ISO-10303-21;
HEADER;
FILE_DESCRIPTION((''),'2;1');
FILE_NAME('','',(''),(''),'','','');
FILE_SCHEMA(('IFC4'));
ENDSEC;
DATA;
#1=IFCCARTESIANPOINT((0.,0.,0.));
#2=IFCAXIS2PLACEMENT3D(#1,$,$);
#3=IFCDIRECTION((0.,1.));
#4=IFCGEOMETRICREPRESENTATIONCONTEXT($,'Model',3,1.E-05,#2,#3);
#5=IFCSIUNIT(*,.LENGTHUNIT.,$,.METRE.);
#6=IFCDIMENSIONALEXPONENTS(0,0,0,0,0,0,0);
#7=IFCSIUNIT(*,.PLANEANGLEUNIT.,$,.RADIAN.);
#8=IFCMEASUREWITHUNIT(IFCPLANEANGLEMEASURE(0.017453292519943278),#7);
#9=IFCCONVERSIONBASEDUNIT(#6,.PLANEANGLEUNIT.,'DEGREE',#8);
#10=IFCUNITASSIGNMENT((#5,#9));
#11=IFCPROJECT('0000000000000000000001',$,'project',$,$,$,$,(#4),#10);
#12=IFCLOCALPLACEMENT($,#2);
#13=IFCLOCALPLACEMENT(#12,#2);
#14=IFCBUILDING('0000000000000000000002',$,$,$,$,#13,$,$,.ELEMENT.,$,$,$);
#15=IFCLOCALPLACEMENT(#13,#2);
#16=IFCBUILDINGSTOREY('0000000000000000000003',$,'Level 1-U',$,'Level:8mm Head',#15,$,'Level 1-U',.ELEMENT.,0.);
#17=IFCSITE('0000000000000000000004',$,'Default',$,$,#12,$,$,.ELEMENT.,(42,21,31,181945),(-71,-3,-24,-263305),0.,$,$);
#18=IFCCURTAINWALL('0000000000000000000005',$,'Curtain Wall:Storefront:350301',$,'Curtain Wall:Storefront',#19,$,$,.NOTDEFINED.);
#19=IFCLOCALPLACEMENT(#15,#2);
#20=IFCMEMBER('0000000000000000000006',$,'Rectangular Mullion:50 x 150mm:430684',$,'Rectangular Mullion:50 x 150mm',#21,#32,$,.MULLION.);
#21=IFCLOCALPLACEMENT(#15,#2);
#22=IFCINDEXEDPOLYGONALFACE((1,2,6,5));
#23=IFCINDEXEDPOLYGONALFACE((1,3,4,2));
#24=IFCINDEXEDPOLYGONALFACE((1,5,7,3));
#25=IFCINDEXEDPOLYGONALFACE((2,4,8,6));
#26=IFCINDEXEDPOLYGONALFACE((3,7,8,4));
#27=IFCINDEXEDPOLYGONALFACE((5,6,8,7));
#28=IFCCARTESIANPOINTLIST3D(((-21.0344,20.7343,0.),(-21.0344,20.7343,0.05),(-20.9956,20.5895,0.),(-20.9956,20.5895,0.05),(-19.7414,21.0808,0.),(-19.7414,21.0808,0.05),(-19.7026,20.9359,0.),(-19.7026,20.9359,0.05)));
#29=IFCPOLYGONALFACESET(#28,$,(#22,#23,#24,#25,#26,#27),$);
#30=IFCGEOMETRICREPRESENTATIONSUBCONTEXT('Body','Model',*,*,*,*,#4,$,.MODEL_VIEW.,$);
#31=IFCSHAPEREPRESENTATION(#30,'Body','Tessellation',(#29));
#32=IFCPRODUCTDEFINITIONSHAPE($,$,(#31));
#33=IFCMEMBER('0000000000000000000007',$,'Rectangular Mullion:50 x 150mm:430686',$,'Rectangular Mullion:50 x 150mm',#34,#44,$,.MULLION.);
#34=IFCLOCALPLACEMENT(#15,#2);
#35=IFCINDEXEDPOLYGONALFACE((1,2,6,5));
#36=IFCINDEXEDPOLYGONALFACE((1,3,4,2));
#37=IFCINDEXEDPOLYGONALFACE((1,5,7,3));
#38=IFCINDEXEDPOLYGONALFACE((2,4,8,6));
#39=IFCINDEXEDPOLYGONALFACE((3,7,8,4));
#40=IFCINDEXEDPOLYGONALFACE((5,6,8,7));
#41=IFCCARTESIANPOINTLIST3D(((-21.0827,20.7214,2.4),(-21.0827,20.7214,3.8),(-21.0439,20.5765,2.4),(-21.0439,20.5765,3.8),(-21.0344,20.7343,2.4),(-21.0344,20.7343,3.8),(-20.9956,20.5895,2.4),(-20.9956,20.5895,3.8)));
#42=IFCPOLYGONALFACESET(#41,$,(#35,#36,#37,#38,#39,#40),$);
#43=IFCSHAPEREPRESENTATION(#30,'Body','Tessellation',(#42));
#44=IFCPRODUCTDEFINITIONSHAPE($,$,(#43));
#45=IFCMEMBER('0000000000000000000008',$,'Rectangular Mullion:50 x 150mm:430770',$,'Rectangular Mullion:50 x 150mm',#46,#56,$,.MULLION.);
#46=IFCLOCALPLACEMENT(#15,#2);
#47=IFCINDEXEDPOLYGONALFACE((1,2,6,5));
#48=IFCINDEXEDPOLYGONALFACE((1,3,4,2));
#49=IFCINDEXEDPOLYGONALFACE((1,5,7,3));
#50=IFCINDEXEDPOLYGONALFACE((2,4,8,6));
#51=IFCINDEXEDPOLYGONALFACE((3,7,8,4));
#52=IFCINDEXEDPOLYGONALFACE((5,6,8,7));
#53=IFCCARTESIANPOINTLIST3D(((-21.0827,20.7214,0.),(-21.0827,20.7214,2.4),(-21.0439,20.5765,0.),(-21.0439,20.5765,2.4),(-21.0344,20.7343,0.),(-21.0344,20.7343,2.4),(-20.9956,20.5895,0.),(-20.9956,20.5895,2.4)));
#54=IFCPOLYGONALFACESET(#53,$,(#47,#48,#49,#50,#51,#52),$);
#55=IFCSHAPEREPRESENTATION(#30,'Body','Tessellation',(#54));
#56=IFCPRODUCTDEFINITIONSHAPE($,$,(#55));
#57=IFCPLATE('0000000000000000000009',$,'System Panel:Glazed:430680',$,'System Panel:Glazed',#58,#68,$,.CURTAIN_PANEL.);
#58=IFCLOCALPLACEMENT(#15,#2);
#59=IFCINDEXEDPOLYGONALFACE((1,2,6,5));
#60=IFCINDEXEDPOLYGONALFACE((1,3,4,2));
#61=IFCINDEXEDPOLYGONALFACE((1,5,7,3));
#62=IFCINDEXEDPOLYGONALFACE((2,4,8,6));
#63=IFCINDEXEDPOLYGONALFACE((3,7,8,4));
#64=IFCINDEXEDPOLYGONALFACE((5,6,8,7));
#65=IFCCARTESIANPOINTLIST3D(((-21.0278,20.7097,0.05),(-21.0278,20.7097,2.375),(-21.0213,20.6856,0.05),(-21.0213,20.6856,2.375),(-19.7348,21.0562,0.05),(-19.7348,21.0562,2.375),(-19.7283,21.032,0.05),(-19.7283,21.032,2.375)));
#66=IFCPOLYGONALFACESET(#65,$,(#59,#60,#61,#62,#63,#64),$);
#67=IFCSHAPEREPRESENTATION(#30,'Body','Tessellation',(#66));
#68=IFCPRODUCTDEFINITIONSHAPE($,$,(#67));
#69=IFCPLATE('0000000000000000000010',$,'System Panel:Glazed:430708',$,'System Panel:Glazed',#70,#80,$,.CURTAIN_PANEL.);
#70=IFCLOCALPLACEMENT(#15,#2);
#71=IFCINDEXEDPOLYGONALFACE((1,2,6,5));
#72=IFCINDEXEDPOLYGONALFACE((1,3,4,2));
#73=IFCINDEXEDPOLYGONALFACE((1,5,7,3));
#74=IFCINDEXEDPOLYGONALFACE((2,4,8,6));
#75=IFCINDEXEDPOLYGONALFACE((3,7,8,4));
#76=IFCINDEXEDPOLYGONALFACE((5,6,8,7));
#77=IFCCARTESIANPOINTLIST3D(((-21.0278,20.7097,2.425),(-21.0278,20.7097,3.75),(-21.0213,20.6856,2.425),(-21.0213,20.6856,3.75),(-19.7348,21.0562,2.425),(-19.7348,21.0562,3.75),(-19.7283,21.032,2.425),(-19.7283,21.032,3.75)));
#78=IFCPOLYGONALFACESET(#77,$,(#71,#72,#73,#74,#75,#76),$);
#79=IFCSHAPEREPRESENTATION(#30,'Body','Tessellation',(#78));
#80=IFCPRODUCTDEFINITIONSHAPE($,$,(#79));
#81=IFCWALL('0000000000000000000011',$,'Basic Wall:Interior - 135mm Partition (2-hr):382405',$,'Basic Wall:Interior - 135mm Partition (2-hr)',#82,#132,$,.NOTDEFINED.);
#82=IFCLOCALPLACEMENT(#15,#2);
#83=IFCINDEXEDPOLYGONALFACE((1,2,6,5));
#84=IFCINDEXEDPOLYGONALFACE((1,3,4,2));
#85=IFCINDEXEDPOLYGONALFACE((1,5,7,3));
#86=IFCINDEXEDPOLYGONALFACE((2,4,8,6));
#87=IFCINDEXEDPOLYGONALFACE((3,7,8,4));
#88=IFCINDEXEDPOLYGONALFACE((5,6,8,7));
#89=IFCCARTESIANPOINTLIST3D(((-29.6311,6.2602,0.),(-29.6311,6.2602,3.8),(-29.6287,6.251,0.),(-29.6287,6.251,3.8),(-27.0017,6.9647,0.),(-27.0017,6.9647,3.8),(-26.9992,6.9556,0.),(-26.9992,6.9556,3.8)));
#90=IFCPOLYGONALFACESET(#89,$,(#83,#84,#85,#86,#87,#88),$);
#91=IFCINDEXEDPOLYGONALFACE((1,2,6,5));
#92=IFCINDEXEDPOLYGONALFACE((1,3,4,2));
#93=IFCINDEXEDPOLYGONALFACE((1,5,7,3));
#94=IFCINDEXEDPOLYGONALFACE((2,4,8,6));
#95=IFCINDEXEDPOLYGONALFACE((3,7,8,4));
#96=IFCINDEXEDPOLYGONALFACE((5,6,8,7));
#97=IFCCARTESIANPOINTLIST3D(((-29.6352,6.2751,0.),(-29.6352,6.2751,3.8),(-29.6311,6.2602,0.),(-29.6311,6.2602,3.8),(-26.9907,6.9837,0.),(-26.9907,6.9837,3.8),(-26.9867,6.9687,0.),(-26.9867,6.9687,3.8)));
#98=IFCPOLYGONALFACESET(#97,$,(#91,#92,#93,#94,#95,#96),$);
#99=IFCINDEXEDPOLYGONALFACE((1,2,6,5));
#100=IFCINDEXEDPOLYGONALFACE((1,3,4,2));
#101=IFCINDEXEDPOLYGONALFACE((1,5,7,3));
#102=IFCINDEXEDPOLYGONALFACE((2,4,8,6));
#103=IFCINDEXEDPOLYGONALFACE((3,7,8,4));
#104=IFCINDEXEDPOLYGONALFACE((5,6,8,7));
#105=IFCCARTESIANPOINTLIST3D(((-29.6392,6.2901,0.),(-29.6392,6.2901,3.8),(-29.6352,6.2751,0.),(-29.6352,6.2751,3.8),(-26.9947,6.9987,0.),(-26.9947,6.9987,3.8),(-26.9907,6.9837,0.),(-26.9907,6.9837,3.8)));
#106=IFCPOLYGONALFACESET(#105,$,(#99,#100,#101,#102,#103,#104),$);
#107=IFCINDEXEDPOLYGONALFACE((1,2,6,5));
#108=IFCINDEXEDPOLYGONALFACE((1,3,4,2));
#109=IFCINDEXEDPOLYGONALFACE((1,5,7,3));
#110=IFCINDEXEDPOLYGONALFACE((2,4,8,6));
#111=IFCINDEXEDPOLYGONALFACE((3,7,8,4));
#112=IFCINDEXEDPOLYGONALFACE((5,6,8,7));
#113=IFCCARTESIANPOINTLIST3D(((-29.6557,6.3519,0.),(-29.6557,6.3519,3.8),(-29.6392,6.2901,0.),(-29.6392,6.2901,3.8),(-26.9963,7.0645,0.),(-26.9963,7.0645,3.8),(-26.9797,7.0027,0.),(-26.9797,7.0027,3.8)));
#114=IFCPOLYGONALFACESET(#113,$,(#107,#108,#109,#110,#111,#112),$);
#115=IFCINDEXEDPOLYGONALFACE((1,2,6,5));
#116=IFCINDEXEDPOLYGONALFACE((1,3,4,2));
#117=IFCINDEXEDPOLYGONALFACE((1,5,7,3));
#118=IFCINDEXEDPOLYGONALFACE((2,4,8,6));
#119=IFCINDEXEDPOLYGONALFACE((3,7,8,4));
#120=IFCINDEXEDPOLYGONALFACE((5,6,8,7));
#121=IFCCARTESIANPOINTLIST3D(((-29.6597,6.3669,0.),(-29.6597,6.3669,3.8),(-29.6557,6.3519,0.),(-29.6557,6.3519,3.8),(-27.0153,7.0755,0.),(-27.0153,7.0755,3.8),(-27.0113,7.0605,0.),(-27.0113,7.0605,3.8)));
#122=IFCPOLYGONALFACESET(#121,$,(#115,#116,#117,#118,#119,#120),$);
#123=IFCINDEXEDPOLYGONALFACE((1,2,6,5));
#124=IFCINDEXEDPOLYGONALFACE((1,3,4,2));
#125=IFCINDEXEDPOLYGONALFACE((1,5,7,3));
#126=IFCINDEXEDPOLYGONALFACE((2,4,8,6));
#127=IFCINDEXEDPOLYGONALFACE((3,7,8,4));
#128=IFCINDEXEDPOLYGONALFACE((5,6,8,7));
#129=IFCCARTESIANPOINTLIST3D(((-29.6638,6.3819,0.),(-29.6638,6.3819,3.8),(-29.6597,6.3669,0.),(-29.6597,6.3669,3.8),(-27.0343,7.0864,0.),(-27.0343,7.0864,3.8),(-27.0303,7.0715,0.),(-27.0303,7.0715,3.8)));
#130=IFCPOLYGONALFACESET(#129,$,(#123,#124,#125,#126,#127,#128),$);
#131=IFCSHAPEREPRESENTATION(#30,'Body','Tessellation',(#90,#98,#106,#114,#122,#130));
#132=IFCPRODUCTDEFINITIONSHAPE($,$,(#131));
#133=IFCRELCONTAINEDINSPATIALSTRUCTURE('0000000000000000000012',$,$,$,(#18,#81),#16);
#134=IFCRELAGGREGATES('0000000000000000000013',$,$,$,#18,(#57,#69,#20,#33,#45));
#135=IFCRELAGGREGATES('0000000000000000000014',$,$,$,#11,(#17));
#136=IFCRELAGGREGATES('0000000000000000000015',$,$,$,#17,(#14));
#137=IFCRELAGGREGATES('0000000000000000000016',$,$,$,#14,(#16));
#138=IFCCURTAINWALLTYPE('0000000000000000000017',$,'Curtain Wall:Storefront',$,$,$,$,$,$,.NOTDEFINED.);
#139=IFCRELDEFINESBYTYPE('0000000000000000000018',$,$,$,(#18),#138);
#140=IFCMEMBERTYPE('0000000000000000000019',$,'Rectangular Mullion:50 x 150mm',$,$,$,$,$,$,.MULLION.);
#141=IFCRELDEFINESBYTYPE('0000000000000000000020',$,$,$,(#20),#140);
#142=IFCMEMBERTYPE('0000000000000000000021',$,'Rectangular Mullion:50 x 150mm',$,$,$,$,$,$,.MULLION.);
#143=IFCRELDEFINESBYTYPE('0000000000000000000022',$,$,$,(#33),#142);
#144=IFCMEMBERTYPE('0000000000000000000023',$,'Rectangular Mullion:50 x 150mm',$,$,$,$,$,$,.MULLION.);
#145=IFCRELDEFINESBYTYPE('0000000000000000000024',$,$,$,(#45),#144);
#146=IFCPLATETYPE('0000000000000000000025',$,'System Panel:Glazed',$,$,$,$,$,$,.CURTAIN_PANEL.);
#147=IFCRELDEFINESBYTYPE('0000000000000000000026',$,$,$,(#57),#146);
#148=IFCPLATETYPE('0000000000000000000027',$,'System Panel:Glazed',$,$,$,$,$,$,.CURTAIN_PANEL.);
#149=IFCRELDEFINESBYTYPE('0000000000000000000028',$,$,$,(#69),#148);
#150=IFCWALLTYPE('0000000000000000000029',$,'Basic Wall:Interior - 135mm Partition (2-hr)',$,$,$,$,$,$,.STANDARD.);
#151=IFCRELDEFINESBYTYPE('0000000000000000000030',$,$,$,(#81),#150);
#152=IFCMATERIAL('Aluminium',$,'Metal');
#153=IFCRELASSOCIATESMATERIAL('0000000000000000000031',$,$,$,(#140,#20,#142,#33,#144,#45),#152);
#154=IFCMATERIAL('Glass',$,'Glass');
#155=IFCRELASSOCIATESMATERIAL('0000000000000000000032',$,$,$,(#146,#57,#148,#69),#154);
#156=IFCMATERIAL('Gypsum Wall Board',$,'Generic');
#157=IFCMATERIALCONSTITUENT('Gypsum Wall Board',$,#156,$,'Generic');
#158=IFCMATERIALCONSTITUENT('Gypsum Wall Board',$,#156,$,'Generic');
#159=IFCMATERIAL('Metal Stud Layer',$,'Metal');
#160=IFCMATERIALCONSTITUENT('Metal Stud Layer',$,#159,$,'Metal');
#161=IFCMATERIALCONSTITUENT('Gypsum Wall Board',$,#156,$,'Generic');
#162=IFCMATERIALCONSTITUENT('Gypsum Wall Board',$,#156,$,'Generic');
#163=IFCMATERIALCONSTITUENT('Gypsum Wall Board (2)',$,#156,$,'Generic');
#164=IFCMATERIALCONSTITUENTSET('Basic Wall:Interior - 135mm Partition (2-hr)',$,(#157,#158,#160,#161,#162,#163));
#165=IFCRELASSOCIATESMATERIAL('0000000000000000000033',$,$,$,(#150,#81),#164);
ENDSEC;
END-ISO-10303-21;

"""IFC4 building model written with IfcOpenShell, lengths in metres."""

from ifc_helpers import new_model, entity, si_unit, converted_unit, direction, frame, origin, place, context, subcontext, project, spatial, indexed_curve, outline, extrude, source, transform, mapped, material, constituent, constituent_set, type_object, type_shapes, element, aggregate, save


model = new_model("IFC4")

# Units and contexts
model_context = context("Model", 3, precision=1e-05, world=origin(), true_north=direction((0.0, 1.0)))
body_context = subcontext(model_context, "Body", "Model", "MODEL_VIEW")
ifc_project = project(units=[si_unit("LENGTHUNIT", "METRE"), converted_unit("PLANEANGLEUNIT", "DEGREE", entity("IfcPlaneAngleMeasure", 0.017453292519943278), si_unit("PLANEANGLEUNIT", "RADIAN"), dimensions=[0, 0, 0, 0, 0, 0, 0])], contexts=[model_context])

# Site, building, storey
site_placement = place(None, origin())
site = spatial("IfcSite", under=ifc_project, at=site_placement, Name="Default", CompositionType="ELEMENT", RefLatitude=(42, 21, 31, 181945), RefLongitude=(-71, -3, -24, -263305), RefElevation=0.0)
building_placement = place(site_placement, origin())
building = spatial("IfcBuilding", under=site, at=building_placement, CompositionType="ELEMENT")
storey_placement = place(building_placement, origin())
storey = spatial("IfcBuildingStorey", under=building, at=storey_placement, Name="Level 1-U", ObjectType="Level:8mm Head", LongName="Level 1-U", CompositionType="ELEMENT", Elevation=0.0)

# Curtain wall, members, plates
curtain_wall_type = type_object("IfcCurtainWallType", Name="Curtain Wall:Storefront", PredefinedType="NOTDEFINED")
curtain_wall_placement = place(storey_placement, origin())
curtain_wall = element("IfcCurtainWall", 1, at=curtain_wall_placement, inside=storey, type_object=curtain_wall_type, Name="Curtain Wall:Storefront:350301", ObjectType="Curtain Wall:Storefront", PredefinedType="NOTDEFINED")
ifc_material_1 = material(Name="Aluminium", Category="Metal")
member_type_1 = type_object("IfcMemberType", Name="Rectangular Mullion:50 x 150mm", PredefinedType="MULLION", material=ifc_material_1)
shared_shape_1 = source(origin(), body_context, "Body", "SweptSolid", [
    extrude(outline(indexed_curve([(-0.025, -0.075), (0.025, -0.075), (0.025, 0.075), (-0.025, 0.075), (-0.025, -0.075)], self_intersect=False)), frame((-0.025, 0.0, -1.3386), z_axis=(0.0, 0.0, 1.0), x_axis=(-1.0, 0.0, 0.0)), (0.0, 0.0, 1.0), 1.3386),
])
type_shapes(member_type_1, [shared_shape_1])
member_1_placement = place(curtain_wall_placement, frame((-21.015, 20.6619, 0.0), z_axis=(-0.965926, -0.258819, 0.0), x_axis=(0.0, 0.0, -1.0)))
member_1 = element("IfcMember", 2, at=member_1_placement, type_object=member_type_1, material=ifc_material_1, Name="Rectangular Mullion:50 x 150mm:430684", ObjectType="Rectangular Mullion:50 x 150mm", PredefinedType="MULLION", context=body_context, shape_type="MappedRepresentation", body=[
    mapped(shared_shape_1, transform((0.0, 0.0, 0.0), scale=1.0)),
])
member_type_2 = type_object("IfcMemberType", Name="Rectangular Mullion:50 x 150mm", PredefinedType="MULLION", material=ifc_material_1)
shared_shape_2 = source(origin(), body_context, "Body", "SweptSolid", [
    extrude(outline(indexed_curve([(-0.025, -0.075), (0.025, -0.075), (0.025, 0.075), (-0.025, 0.075), (-0.025, -0.075)], self_intersect=False)), frame((-0.025, 0.0, -1.4), z_axis=(0.0, 0.0, 1.0), x_axis=(-1.0, 0.0, 0.0)), (0.0, 0.0, 1.0), 1.4),
])
type_shapes(member_type_2, [shared_shape_2])
member_2_placement = place(curtain_wall_placement, frame((-21.0633, 20.649, 3.8), z_axis=(0.0, 0.0, 1.0), x_axis=(-0.965926, -0.258819, 0.0)))
member_2 = element("IfcMember", 3, at=member_2_placement, type_object=member_type_2, material=ifc_material_1, Name="Rectangular Mullion:50 x 150mm:430686", ObjectType="Rectangular Mullion:50 x 150mm", PredefinedType="MULLION", context=body_context, shape_type="MappedRepresentation", body=[
    mapped(shared_shape_2, transform((0.0, 0.0, 0.0), scale=1.0)),
])
member_type_3 = type_object("IfcMemberType", Name="Rectangular Mullion:50 x 150mm", PredefinedType="MULLION", material=ifc_material_1)
shared_shape_3 = source(origin(), body_context, "Body", "SweptSolid", [
    extrude(outline(indexed_curve([(-0.025, -0.075), (0.025, -0.075), (0.025, 0.075), (-0.025, 0.075), (-0.025, -0.075)], self_intersect=False)), frame((-0.025, 0.0, -2.4), z_axis=(0.0, 0.0, 1.0), x_axis=(-1.0, 0.0, 0.0)), (0.0, 0.0, 1.0), 2.4),
])
type_shapes(member_type_3, [shared_shape_3])
member_3_placement = place(curtain_wall_placement, frame((-21.0633, 20.649, 2.4), z_axis=(0.0, 0.0, 1.0), x_axis=(-0.965926, -0.258819, 0.0)))
member_3 = element("IfcMember", 4, at=member_3_placement, type_object=member_type_3, material=ifc_material_1, Name="Rectangular Mullion:50 x 150mm:430770", ObjectType="Rectangular Mullion:50 x 150mm", PredefinedType="MULLION", context=body_context, shape_type="MappedRepresentation", body=[
    mapped(shared_shape_3, transform((0.0, 0.0, 0.0), scale=1.0)),
])
ifc_material_2 = material(Name="Glass", Category="Glass")
plate_type_1 = type_object("IfcPlateType", Name="System Panel:Glazed", PredefinedType="CURTAIN_PANEL", material=ifc_material_2)
shared_shape_4 = source(origin(), body_context, "Body", "SweptSolid", [
    extrude(outline(indexed_curve([(-0.0125, -0.6693), (0.0125, -0.6693), (0.0125, 0.6693), (-0.0125, 0.6693), (-0.0125, -0.6693)], self_intersect=False)), frame((0.0, 0.037, 0.0), z_axis=(0.0, 0.0, 1.0), x_axis=(0.0, 1.0, 0.0)), (0.0, 0.0, 1.0), 2.325),
])
type_shapes(plate_type_1, [shared_shape_4])
plate_1_placement = place(curtain_wall_placement, frame((-20.3685, 20.8351, 0.05), z_axis=(0.0, 0.0, 1.0), x_axis=(0.965926, 0.258819, 0.0)))
plate_1 = element("IfcPlate", 5, at=plate_1_placement, type_object=plate_type_1, material=ifc_material_2, Name="System Panel:Glazed:430680", ObjectType="System Panel:Glazed", PredefinedType="CURTAIN_PANEL", context=body_context, shape_type="MappedRepresentation", body=[
    mapped(shared_shape_4, transform((0.0, 0.0, 0.0), scale=1.0)),
])
plate_type_2 = type_object("IfcPlateType", Name="System Panel:Glazed", PredefinedType="CURTAIN_PANEL", material=ifc_material_2)
shared_shape_5 = source(origin(), body_context, "Body", "SweptSolid", [
    extrude(outline(indexed_curve([(-0.0125, -0.6693), (0.0125, -0.6693), (0.0125, 0.6693), (-0.0125, 0.6693), (-0.0125, -0.6693)], self_intersect=False)), frame((0.0, 0.037, 0.0), z_axis=(0.0, 0.0, 1.0), x_axis=(0.0, 1.0, 0.0)), (0.0, 0.0, 1.0), 1.325),
])
type_shapes(plate_type_2, [shared_shape_5])
plate_2_placement = place(curtain_wall_placement, frame((-20.3685, 20.8351, 2.425), z_axis=(0.0, 0.0, 1.0), x_axis=(0.965926, 0.258819, 0.0)))
plate_2 = element("IfcPlate", 6, at=plate_2_placement, type_object=plate_type_2, material=ifc_material_2, Name="System Panel:Glazed:430708", ObjectType="System Panel:Glazed", PredefinedType="CURTAIN_PANEL", context=body_context, shape_type="MappedRepresentation", body=[
    mapped(shared_shape_5, transform((0.0, 0.0, 0.0), scale=1.0)),
])
aggregate(curtain_wall, [plate_1, plate_2, member_1, member_2, member_3])

# Shared definitions
ifc_material_3 = material(Name="Gypsum Wall Board", Category="Generic")
ifc_constituent_1 = constituent(ifc_material_3, Name="Gypsum Wall Board", Category="Generic")
ifc_constituent_2 = constituent(ifc_material_3, Name="Gypsum Wall Board", Category="Generic")
ifc_material_4 = material(Name="Metal Stud Layer", Category="Metal")
ifc_constituent_3 = constituent(ifc_material_4, Name="Metal Stud Layer", Category="Metal")
ifc_constituent_4 = constituent(ifc_material_3, Name="Gypsum Wall Board", Category="Generic")
ifc_constituent_5 = constituent(ifc_material_3, Name="Gypsum Wall Board", Category="Generic")
ifc_constituent_6 = constituent(ifc_material_3, Name="Gypsum Wall Board (2)", Category="Generic")
ifc_constituent_set_1 = constituent_set(constituents=[ifc_constituent_1, ifc_constituent_2, ifc_constituent_3, ifc_constituent_4, ifc_constituent_5, ifc_constituent_6], Name="Basic Wall:Interior - 135mm Partition (2-hr)")
wall_type = type_object("IfcWallType", Name="Basic Wall:Interior - 135mm Partition (2-hr)", PredefinedType="STANDARD", material=ifc_constituent_set_1)

# Wall
wall_1_placement = place(storey_placement, frame((-29.6462, 6.3164, 0.0), z_axis=(0.0, 0.0, 1.0), x_axis=(0.965926, 0.258819, 0.0)))
element("IfcWall", 7, at=wall_1_placement, inside=storey, type_object=wall_type, material=ifc_constituent_set_1, Name="Basic Wall:Interior - 135mm Partition (2-hr):382405", ObjectType="Basic Wall:Interior - 135mm Partition (2-hr)", PredefinedType="NOTDEFINED", context=body_context, shape_type="SweptSolid", body=[
    extrude(outline(indexed_curve([(-0.0047, -1.3611), (0.0048, -1.3611), (0.0047, 1.3611), (-0.0048, 1.3611), (-0.0047, -1.3611)], self_intersect=False)), frame((1.3611, -0.063, 0.0), z_axis=(0.0, 0.0, 1.0), x_axis=(0.0, 1.0, 0.0)), (0.0, 0.0, 1.0), 3.8),
    extrude(outline(indexed_curve([(-1.3689, -0.0077), (1.3689, -0.0078), (1.3689, 0.0077), (-1.3689, 0.0078), (-1.3689, -0.0077)], self_intersect=False)), frame((1.3689, -0.0505, 0.0)), (0.0, 0.0, 1.0), 3.8),
    extrude(outline(indexed_curve([(-1.3689, -0.0077), (1.3689, -0.0078), (1.3689, 0.0077), (-1.3689, 0.0078), (-1.3689, -0.0077)], self_intersect=False)), frame((1.3689, -0.035, 0.0)), (0.0, 0.0, 1.0), 3.8),
    extrude(outline(indexed_curve([(-1.3766, -0.032), (1.3766, -0.032), (1.3766, 0.032), (-1.3766, 0.032), (-1.3766, -0.032)], self_intersect=False)), frame((1.3766, 0.0048, 0.0)), (0.0, 0.0, 1.0), 3.8),
    extrude(outline(indexed_curve([(-1.3689, -0.0077), (1.3689, -0.0078), (1.3689, 0.0077), (-1.3689, 0.0078), (-1.3689, -0.0077)], self_intersect=False)), frame((1.3689, 0.0445, 0.0)), (0.0, 0.0, 1.0), 3.8),
    extrude(outline(indexed_curve([(-0.0078, -1.3611), (0.0077, -1.3611), (0.0078, 1.3611), (-0.0077, 1.3611), (-0.0078, -1.3611)], self_intersect=False)), frame((1.3611, 0.06, 0.0), z_axis=(0.0, 0.0, 1.0), x_axis=(0.0, -1.0, 0.0)), (0.0, 0.0, 1.0), 3.8),
])

save(model, "model.ifc")
